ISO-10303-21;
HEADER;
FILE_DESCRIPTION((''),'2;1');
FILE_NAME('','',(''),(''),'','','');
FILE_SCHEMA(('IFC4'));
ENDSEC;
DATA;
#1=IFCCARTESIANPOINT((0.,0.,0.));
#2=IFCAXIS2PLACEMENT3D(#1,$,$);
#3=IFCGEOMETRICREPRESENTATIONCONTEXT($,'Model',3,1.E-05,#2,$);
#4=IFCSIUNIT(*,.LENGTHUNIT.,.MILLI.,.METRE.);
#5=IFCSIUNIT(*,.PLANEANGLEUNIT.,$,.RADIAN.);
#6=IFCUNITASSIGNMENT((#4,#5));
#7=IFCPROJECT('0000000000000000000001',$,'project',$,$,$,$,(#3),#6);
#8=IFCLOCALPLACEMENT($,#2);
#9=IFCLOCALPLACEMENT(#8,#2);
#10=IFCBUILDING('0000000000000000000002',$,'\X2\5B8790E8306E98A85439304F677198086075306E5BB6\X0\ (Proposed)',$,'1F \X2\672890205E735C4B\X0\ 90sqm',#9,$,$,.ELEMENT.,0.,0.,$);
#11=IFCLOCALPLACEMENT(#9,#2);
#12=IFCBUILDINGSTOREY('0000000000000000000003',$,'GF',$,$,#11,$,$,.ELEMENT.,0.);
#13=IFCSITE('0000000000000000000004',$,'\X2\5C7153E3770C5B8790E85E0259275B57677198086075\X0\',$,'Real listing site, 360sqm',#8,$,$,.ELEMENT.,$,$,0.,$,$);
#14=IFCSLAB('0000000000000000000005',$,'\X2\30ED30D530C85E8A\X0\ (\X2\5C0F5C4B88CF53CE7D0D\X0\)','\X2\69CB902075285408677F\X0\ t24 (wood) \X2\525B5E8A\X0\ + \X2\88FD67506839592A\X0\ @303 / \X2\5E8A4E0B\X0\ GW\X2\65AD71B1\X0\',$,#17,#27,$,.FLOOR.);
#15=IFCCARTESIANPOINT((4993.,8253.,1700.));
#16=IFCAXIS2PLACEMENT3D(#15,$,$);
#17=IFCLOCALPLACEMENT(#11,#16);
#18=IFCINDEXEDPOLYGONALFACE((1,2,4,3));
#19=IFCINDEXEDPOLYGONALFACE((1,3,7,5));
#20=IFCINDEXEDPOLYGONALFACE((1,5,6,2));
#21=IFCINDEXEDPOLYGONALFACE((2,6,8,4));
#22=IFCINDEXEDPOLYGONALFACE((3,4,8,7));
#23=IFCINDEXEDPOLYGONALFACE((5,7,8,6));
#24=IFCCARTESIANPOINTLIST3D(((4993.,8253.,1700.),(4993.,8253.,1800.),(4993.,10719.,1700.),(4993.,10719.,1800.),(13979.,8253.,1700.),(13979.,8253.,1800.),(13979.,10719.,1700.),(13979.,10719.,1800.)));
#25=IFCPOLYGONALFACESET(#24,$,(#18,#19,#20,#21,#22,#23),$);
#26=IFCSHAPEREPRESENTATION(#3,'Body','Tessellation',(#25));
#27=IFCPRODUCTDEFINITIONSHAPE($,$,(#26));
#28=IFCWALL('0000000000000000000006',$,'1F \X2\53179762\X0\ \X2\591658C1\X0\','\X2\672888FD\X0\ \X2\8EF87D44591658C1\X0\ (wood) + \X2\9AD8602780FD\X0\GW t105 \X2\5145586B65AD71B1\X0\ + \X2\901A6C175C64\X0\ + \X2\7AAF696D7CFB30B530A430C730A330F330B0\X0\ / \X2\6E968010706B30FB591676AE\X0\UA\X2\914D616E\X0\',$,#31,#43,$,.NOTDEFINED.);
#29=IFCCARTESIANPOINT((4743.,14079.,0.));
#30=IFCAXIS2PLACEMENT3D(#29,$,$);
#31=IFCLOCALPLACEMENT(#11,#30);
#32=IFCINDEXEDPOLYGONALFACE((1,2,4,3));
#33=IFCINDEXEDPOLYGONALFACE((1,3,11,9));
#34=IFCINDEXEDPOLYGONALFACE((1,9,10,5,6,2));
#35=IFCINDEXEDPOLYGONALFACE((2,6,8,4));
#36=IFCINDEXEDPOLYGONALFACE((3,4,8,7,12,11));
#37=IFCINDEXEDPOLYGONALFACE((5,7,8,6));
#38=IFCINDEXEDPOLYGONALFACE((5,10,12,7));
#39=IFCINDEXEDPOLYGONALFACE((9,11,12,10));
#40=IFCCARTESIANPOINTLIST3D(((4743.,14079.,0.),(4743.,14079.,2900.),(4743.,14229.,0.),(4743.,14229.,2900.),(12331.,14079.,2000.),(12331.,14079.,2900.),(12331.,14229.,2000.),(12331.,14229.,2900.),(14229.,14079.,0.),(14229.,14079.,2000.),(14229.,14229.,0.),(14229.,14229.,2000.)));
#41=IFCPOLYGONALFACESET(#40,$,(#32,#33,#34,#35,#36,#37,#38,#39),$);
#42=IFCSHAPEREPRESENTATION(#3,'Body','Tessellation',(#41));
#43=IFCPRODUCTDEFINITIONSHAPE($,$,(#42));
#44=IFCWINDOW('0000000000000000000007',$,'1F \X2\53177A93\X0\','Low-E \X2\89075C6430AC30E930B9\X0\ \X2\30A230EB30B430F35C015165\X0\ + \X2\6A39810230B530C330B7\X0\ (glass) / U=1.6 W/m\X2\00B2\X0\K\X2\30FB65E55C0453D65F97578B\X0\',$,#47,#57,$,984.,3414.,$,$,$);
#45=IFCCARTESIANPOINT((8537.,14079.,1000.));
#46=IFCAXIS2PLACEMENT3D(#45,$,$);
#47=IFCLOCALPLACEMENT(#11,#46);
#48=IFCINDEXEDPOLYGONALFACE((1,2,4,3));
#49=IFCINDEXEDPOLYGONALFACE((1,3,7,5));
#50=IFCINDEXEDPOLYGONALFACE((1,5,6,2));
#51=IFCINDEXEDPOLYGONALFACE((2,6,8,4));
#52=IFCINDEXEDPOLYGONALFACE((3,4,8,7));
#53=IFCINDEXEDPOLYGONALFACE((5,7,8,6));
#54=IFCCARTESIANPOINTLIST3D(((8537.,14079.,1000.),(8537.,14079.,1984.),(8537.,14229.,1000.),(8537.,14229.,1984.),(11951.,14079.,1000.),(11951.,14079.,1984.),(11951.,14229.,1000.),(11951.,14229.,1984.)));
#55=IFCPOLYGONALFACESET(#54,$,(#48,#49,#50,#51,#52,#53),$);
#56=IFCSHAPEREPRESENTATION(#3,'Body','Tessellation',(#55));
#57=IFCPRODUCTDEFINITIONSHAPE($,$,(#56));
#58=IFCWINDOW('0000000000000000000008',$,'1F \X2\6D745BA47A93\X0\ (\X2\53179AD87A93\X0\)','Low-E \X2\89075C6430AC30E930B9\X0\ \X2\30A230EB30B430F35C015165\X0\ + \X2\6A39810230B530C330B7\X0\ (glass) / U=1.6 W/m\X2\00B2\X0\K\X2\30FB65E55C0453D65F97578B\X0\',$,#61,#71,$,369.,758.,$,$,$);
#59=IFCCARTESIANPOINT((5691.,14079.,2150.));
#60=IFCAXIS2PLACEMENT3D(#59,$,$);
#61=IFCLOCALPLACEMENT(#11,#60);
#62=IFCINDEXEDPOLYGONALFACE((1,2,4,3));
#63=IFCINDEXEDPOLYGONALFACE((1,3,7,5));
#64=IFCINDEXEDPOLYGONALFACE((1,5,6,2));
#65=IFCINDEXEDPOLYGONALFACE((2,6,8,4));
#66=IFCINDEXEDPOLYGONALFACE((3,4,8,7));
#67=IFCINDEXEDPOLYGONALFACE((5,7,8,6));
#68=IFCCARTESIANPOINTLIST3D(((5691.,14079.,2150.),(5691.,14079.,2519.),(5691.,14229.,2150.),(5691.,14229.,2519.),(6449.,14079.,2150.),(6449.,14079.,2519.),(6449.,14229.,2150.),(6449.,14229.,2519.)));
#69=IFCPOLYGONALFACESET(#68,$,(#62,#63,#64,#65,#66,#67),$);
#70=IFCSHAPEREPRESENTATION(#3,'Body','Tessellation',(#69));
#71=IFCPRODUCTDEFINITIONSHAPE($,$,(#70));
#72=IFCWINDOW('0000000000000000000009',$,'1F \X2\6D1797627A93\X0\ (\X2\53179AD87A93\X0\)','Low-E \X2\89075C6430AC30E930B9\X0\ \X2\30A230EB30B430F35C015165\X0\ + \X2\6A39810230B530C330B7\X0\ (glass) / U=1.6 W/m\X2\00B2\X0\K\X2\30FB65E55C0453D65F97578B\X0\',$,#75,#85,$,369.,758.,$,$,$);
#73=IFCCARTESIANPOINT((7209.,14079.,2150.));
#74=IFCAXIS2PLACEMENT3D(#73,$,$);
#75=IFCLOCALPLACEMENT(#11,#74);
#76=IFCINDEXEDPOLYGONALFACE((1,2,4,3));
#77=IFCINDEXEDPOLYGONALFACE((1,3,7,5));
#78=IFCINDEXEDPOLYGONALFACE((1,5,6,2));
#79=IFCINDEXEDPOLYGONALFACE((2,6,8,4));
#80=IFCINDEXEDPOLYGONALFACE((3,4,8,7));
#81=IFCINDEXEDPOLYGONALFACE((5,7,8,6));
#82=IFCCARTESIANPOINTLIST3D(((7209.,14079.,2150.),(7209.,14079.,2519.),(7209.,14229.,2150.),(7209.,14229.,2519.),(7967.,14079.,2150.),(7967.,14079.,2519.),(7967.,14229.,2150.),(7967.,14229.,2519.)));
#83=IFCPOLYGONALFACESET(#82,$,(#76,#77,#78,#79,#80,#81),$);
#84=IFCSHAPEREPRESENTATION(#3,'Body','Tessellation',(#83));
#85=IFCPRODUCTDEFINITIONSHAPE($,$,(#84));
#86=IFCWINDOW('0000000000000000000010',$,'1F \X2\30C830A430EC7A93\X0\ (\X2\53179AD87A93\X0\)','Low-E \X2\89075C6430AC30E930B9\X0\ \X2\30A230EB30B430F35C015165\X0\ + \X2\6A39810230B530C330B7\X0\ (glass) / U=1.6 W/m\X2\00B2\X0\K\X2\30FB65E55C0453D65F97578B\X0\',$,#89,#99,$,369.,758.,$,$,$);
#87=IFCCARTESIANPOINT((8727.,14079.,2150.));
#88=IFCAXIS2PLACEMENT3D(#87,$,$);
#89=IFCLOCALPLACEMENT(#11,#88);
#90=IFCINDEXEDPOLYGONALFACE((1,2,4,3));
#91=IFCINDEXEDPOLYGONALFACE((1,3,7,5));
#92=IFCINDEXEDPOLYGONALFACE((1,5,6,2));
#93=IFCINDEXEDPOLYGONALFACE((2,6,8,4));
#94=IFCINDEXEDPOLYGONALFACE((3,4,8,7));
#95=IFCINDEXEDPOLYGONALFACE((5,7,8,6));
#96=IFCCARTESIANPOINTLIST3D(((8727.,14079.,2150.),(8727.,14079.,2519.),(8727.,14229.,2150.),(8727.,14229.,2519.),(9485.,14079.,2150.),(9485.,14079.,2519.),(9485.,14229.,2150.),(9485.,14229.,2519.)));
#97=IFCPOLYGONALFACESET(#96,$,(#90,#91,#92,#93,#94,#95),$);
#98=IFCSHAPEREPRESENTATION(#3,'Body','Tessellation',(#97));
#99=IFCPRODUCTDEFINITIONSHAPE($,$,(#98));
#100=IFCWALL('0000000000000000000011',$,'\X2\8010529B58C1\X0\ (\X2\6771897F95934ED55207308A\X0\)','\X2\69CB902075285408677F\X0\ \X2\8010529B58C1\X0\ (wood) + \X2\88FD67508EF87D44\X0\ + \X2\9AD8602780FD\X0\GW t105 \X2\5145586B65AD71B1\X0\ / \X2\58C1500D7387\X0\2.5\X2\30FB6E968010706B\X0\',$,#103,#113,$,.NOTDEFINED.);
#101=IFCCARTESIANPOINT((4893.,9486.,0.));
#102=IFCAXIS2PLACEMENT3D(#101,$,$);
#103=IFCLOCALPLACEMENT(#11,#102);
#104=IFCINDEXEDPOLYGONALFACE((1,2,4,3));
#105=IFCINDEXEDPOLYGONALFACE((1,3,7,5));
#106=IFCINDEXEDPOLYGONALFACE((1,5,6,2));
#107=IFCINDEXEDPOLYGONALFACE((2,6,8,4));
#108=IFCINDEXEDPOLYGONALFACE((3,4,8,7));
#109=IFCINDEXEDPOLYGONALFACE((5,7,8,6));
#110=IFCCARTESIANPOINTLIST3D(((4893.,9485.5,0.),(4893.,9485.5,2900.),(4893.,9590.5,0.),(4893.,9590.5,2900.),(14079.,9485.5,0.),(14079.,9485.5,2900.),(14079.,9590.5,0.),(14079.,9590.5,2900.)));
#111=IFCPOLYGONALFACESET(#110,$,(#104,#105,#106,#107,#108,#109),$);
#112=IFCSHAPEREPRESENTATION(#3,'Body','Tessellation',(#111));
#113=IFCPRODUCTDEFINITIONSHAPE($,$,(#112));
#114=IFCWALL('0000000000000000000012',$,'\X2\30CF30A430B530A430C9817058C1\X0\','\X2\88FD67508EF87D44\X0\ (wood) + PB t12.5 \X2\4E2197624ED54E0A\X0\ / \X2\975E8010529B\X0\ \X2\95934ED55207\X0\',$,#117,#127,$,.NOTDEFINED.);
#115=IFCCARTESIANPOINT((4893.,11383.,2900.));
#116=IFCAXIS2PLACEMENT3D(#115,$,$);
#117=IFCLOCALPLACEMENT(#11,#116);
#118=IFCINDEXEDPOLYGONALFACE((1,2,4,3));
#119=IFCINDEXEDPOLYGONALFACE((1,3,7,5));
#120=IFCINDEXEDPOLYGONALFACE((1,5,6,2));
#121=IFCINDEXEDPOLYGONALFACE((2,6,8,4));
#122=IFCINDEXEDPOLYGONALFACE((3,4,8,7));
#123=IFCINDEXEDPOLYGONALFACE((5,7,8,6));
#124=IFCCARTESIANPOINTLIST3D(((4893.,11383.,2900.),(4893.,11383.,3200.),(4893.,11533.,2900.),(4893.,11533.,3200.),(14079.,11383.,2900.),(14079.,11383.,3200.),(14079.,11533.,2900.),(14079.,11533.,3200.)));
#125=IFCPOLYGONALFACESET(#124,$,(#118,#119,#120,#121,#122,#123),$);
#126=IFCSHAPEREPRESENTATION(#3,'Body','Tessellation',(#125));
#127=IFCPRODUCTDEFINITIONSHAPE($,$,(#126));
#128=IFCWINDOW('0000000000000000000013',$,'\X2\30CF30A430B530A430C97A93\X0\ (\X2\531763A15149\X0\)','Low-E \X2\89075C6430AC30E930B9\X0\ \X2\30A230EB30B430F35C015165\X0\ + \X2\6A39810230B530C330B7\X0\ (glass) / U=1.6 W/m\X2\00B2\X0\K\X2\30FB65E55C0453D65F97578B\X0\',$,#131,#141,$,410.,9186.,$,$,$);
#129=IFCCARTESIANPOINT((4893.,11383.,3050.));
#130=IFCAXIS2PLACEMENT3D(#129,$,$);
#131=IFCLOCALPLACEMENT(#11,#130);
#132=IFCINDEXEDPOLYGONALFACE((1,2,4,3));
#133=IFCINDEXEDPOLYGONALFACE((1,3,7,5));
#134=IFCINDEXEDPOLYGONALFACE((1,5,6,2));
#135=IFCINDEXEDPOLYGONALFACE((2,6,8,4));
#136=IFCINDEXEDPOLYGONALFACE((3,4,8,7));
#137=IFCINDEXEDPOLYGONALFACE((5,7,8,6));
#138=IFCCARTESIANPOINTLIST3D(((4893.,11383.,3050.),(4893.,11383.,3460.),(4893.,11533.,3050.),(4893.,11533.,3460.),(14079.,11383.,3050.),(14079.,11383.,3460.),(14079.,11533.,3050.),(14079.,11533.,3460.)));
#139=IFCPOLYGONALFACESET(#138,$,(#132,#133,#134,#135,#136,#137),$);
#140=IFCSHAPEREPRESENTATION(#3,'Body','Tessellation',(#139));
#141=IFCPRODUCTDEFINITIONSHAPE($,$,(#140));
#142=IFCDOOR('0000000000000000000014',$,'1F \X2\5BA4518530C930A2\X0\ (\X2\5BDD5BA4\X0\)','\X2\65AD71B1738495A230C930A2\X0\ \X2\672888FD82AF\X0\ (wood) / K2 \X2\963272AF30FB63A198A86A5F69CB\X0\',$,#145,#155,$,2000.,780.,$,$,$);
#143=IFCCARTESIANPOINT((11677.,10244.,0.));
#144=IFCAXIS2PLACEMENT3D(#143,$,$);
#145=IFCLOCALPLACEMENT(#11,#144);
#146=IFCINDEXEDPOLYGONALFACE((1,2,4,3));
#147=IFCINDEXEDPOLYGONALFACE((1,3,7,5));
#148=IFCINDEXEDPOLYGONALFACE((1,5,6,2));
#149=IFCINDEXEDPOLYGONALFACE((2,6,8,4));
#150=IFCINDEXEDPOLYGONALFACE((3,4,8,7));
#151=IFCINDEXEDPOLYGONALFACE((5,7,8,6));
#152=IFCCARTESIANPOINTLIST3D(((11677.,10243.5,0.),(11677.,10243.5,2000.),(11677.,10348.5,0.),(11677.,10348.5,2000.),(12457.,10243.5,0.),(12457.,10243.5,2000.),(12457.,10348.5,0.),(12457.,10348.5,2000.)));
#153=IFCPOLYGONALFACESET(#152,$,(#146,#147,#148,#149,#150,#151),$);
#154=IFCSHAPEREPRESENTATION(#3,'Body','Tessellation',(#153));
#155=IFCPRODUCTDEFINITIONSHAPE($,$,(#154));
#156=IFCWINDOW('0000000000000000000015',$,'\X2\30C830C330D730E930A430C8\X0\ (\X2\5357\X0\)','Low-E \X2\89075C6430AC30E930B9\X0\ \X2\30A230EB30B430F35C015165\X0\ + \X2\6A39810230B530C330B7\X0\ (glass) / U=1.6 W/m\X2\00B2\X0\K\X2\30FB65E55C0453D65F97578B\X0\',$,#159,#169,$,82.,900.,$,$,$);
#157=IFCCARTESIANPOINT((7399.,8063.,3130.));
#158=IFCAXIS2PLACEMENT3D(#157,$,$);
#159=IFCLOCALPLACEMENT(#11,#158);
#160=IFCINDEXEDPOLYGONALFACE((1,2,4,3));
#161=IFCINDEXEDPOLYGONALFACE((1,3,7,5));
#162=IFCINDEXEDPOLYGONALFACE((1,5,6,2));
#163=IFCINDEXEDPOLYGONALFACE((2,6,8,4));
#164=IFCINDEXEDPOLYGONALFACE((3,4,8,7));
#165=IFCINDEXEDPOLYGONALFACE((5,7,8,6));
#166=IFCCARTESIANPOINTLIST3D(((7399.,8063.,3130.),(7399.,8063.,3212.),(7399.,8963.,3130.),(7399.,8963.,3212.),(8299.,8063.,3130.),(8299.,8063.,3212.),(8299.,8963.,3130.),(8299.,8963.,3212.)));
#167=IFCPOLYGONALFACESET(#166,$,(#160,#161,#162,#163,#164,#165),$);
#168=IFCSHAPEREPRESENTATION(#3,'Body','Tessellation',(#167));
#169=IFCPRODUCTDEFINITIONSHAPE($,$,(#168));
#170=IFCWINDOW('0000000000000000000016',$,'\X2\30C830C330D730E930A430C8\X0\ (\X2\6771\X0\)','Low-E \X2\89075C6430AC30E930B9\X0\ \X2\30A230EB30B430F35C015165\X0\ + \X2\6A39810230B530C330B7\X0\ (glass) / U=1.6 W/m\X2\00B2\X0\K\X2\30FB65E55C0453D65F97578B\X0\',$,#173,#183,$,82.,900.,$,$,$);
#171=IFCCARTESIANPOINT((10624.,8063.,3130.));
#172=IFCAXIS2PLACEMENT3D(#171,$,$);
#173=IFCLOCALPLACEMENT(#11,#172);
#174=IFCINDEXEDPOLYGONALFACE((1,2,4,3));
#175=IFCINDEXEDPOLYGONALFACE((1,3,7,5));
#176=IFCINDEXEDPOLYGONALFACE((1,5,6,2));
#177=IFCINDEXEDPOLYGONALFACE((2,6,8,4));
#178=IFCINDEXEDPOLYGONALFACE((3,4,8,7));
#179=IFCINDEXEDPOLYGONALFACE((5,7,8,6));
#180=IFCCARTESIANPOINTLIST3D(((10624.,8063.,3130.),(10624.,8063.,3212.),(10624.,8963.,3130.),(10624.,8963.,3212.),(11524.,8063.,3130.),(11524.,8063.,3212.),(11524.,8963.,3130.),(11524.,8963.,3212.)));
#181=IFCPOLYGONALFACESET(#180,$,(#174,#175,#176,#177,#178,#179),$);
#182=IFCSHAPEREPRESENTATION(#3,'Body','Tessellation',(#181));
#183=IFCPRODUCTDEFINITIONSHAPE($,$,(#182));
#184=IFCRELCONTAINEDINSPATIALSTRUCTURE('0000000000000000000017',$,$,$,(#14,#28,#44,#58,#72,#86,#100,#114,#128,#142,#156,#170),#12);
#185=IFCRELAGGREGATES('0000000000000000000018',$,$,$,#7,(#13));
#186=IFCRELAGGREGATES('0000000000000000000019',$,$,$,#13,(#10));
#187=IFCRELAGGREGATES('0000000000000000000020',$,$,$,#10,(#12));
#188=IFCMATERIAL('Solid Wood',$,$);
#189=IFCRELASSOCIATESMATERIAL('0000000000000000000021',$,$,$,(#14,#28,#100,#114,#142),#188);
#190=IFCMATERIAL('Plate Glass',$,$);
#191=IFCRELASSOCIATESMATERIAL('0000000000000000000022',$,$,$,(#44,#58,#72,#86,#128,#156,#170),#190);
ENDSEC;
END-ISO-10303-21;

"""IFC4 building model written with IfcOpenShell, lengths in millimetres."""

from ifc_helpers import new_model, si_unit, frame, frame_2d, origin, place, context, project, spatial, rectangle, extrude, material, element, fill, save


model = new_model("IFC4")

# Units and contexts
model_context = context("Model", 3, precision=1e-05, world=origin())
ifc_project = project(units=[si_unit("LENGTHUNIT", "METRE", prefix="MILLI"), si_unit("PLANEANGLEUNIT", "RADIAN")], contexts=[model_context])

# Site, building, storey
site_placement = place(None, origin())
site = spatial("IfcSite", under=ifc_project, at=site_placement, Name="山口県宇部市大字東須恵", ObjectType="Real listing site, 360sqm", CompositionType="ELEMENT", RefElevation=0.0)
building_placement = place(site_placement, origin())
building = spatial("IfcBuilding", under=site, at=building_placement, Name="宇部の風吹く東須恵の家 (Proposed)", ObjectType="1F 木造平屋 90sqm", CompositionType="ELEMENT", ElevationOfRefHeight=0.0, ElevationOfTerrain=0.0)
storey_placement = place(building_placement, origin())
storey = spatial("IfcBuildingStorey", under=building, at=storey_placement, Name="GF", CompositionType="ELEMENT", Elevation=0.0)

# Slab
ifc_material_1 = material(Name="Solid Wood")
slab_placement = place(storey_placement, frame((4993.0, 8253.0, 1700.0)))
element("IfcSlab", 1, at=slab_placement, inside=storey, material=ifc_material_1, Name="ロフト床 (小屋裏収納)", Description="構造用合板 t24 (wood) 剛床 + 製材根太 @303 / 床下 GW断熱", PredefinedType="FLOOR", context=model_context, shape_type="SweptSolid", body=[
    extrude(rectangle(XDim=8986.0, YDim=2466.0, at=frame_2d((4493.0, 1233.0))), frame((4993.0, 8253.0, 1700.0)), (0.0, 0.0, 1.0), 100.0),
])

# Wall, openings, windows
wall_1_placement = place(storey_placement, frame((4743.0, 14079.0, 0.0)))
wall_1 = element("IfcWall", 2, at=wall_1_placement, inside=storey, material=ifc_material_1, Name="1F 北面 外壁", Description="木製 軸組外壁 (wood) + 高性能GW t105 充填断熱 + 通気層 + 窯業系サイディング / 準耐火・外皮UA配慮", PredefinedType="NOTDEFINED", context=model_context, shape_type="SweptSolid", body=[
    extrude(rectangle(XDim=9486.0, YDim=150.0, at=frame_2d((4743.0, 75.0))), frame((4743.0, 14079.0, 0.0)), (0.0, 0.0, 1.0), 2900.0),
])
opening_1_placement = place(storey_placement, frame((8537.0, 14079.0, 1000.0)))
opening_1 = element("IfcOpeningElement", 3, at=opening_1_placement, cuts=wall_1, PredefinedType="NOTDEFINED", context=model_context, shape_type="SweptSolid", body=[
    extrude(rectangle(XDim=3414.0, YDim=150.0, at=frame_2d((1707.0, 75.0))), frame((8537.0, 14079.0, 1000.0)), (0.0, 0.0, 1.0), 984.0),
])
opening_2_placement = place(storey_placement, frame((5691.0, 14079.0, 2150.0)))
opening_2 = element("IfcOpeningElement", 4, at=opening_2_placement, cuts=wall_1, PredefinedType="NOTDEFINED", context=model_context, shape_type="SweptSolid", body=[
    extrude(rectangle(XDim=758.0, YDim=150.0, at=frame_2d((379.0, 75.0))), frame((5691.0, 14079.0, 2150.0)), (0.0, 0.0, 1.0), 369.0),
])
opening_3_placement = place(storey_placement, frame((7209.0, 14079.0, 2150.0)))
opening_3 = element("IfcOpeningElement", 5, at=opening_3_placement, cuts=wall_1, PredefinedType="NOTDEFINED", context=model_context, shape_type="SweptSolid", body=[
    extrude(rectangle(XDim=758.0, YDim=150.0, at=frame_2d((379.0, 75.0))), frame((7209.0, 14079.0, 2150.0)), (0.0, 0.0, 1.0), 369.0),
])
opening_4_placement = place(storey_placement, frame((8727.0, 14079.0, 2150.0)))
opening_4 = element("IfcOpeningElement", 6, at=opening_4_placement, cuts=wall_1, PredefinedType="NOTDEFINED", context=model_context, shape_type="SweptSolid", body=[
    extrude(rectangle(XDim=758.0, YDim=150.0, at=frame_2d((379.0, 75.0))), frame((8727.0, 14079.0, 2150.0)), (0.0, 0.0, 1.0), 369.0),
])
ifc_material_2 = material(Name="Plate Glass")
window_1_placement = place(storey_placement, frame((8537.0, 14079.0, 1000.0)))
window_1 = element("IfcWindow", 7, at=window_1_placement, inside=storey, material=ifc_material_2, Name="1F 北窓", Description="Low-E 複層ガラス アルゴン封入 + 樹脂サッシ (glass) / U=1.6 W/m²K・日射取得型", OverallHeight=984.0, OverallWidth=3414.0, context=model_context, shape_type="SweptSolid", body=[
    extrude(rectangle(XDim=3414.0, YDim=150.0, at=frame_2d((1707.0, 75.0))), frame((8537.0, 14079.0, 1000.0)), (0.0, 0.0, 1.0), 984.0),
])
fill(opening_1, window_1)
window_2_placement = place(storey_placement, frame((5691.0, 14079.0, 2150.0)))
window_2 = element("IfcWindow", 8, at=window_2_placement, inside=storey, material=ifc_material_2, Name="1F 浴室窓 (北高窓)", Description="Low-E 複層ガラス アルゴン封入 + 樹脂サッシ (glass) / U=1.6 W/m²K・日射取得型", OverallHeight=369.0, OverallWidth=758.0, context=model_context, shape_type="SweptSolid", body=[
    extrude(rectangle(XDim=758.0, YDim=150.0, at=frame_2d((379.0, 75.0))), frame((5691.0, 14079.0, 2150.0)), (0.0, 0.0, 1.0), 369.0),
])
fill(opening_2, window_2)
window_3_placement = place(storey_placement, frame((7209.0, 14079.0, 2150.0)))
window_3 = element("IfcWindow", 9, at=window_3_placement, inside=storey, material=ifc_material_2, Name="1F 洗面窓 (北高窓)", Description="Low-E 複層ガラス アルゴン封入 + 樹脂サッシ (glass) / U=1.6 W/m²K・日射取得型", OverallHeight=369.0, OverallWidth=758.0, context=model_context, shape_type="SweptSolid", body=[
    extrude(rectangle(XDim=758.0, YDim=150.0, at=frame_2d((379.0, 75.0))), frame((7209.0, 14079.0, 2150.0)), (0.0, 0.0, 1.0), 369.0),
])
fill(opening_3, window_3)
window_4_placement = place(storey_placement, frame((8727.0, 14079.0, 2150.0)))
window_4 = element("IfcWindow", 10, at=window_4_placement, inside=storey, material=ifc_material_2, Name="1F トイレ窓 (北高窓)", Description="Low-E 複層ガラス アルゴン封入 + 樹脂サッシ (glass) / U=1.6 W/m²K・日射取得型", OverallHeight=369.0, OverallWidth=758.0, context=model_context, shape_type="SweptSolid", body=[
    extrude(rectangle(XDim=758.0, YDim=150.0, at=frame_2d((379.0, 75.0))), frame((8727.0, 14079.0, 2150.0)), (0.0, 0.0, 1.0), 369.0),
])
fill(opening_4, window_4)

# Wall
wall_2_placement = place(storey_placement, frame((4893.0, 9486.0, 0.0)))
element("IfcWall", 11, at=wall_2_placement, inside=storey, material=ifc_material_1, Name="耐力壁 (東西間仕切り)", Description="構造用合板 耐力壁 (wood) + 製材軸組 + 高性能GW t105 充填断熱 / 壁倍率2.5・準耐火", PredefinedType="NOTDEFINED", context=model_context, shape_type="SweptSolid", body=[
    extrude(rectangle(XDim=9186.0, YDim=105.0, at=frame_2d((4593.0, 52.0))), frame((4893.0, 9486.0, 0.0)), (0.0, 0.0, 1.0), 2900.0),
])

# Wall, opening, window
wall_3_placement = place(storey_placement, frame((4893.0, 11383.0, 2900.0)))
wall_3 = element("IfcWall", 12, at=wall_3_placement, inside=storey, material=ifc_material_1, Name="ハイサイド腰壁", Description="製材軸組 (wood) + PB t12.5 両面仕上 / 非耐力 間仕切", PredefinedType="NOTDEFINED", context=model_context, shape_type="SweptSolid", body=[
    extrude(rectangle(XDim=9186.0, YDim=150.0, at=frame_2d((4593.0, 75.0))), frame((4893.0, 11383.0, 2900.0)), (0.0, 0.0, 1.0), 700.0),
])
opening_5_placement = place(storey_placement, frame((4893.0, 11383.0, 3050.0)))
opening_5 = element("IfcOpeningElement", 13, at=opening_5_placement, cuts=wall_3, PredefinedType="NOTDEFINED", context=model_context, shape_type="SweptSolid", body=[
    extrude(rectangle(XDim=9186.0, YDim=150.0, at=frame_2d((4593.0, 75.0))), frame((4893.0, 11383.0, 3050.0)), (0.0, 0.0, 1.0), 410.0),
])
window_5_placement = place(storey_placement, frame((4893.0, 11383.0, 3050.0)))
window_5 = element("IfcWindow", 14, at=window_5_placement, inside=storey, material=ifc_material_2, Name="ハイサイド窓 (北採光)", Description="Low-E 複層ガラス アルゴン封入 + 樹脂サッシ (glass) / U=1.6 W/m²K・日射取得型", OverallHeight=410.0, OverallWidth=9186.0, context=model_context, shape_type="SweptSolid", body=[
    extrude(rectangle(XDim=9186.0, YDim=150.0, at=frame_2d((4593.0, 75.0))), frame((4893.0, 11383.0, 3050.0)), (0.0, 0.0, 1.0), 410.0),
])
fill(opening_5, window_5)

# Door
door_1_placement = place(storey_placement, frame((11677.0, 10244.0, 0.0)))
element("IfcDoor", 15, at=door_1_placement, inside=storey, material=ifc_material_1, Name="1F 室内ドア (寝室)", Description="断熱玄関ドア 木製芯 (wood) / K2 防犯・採風機構", OverallHeight=2000.0, OverallWidth=780.0, context=model_context, shape_type="SweptSolid", body=[
    extrude(rectangle(XDim=780.0, YDim=105.0, at=frame_2d((390.0, 52.0))), frame((11677.0, 10244.0, 0.0)), (0.0, 0.0, 1.0), 2000.0),
])

# Windows
window_6_placement = place(storey_placement, frame((7399.0, 8063.0, 3130.0)))
element("IfcWindow", 16, at=window_6_placement, inside=storey, material=ifc_material_2, Name="トップライト (南)", Description="Low-E 複層ガラス アルゴン封入 + 樹脂サッシ (glass) / U=1.6 W/m²K・日射取得型", OverallHeight=82.0, OverallWidth=900.0, context=model_context, shape_type="SweptSolid", body=[
    extrude(rectangle(XDim=900.0, YDim=900.0, at=frame_2d((450.0, 450.0))), frame((7399.0, 8063.0, 3130.0)), (0.0, 0.0, 1.0), 82.0),
])
window_7_placement = place(storey_placement, frame((10624.0, 8063.0, 3130.0)))
element("IfcWindow", 17, at=window_7_placement, inside=storey, material=ifc_material_2, Name="トップライト (東)", Description="Low-E 複層ガラス アルゴン封入 + 樹脂サッシ (glass) / U=1.6 W/m²K・日射取得型", OverallHeight=82.0, OverallWidth=900.0, context=model_context, shape_type="SweptSolid", body=[
    extrude(rectangle(XDim=900.0, YDim=900.0, at=frame_2d((450.0, 450.0))), frame((10624.0, 8063.0, 3130.0)), (0.0, 0.0, 1.0), 82.0),
])

save(model, "model.ifc")
